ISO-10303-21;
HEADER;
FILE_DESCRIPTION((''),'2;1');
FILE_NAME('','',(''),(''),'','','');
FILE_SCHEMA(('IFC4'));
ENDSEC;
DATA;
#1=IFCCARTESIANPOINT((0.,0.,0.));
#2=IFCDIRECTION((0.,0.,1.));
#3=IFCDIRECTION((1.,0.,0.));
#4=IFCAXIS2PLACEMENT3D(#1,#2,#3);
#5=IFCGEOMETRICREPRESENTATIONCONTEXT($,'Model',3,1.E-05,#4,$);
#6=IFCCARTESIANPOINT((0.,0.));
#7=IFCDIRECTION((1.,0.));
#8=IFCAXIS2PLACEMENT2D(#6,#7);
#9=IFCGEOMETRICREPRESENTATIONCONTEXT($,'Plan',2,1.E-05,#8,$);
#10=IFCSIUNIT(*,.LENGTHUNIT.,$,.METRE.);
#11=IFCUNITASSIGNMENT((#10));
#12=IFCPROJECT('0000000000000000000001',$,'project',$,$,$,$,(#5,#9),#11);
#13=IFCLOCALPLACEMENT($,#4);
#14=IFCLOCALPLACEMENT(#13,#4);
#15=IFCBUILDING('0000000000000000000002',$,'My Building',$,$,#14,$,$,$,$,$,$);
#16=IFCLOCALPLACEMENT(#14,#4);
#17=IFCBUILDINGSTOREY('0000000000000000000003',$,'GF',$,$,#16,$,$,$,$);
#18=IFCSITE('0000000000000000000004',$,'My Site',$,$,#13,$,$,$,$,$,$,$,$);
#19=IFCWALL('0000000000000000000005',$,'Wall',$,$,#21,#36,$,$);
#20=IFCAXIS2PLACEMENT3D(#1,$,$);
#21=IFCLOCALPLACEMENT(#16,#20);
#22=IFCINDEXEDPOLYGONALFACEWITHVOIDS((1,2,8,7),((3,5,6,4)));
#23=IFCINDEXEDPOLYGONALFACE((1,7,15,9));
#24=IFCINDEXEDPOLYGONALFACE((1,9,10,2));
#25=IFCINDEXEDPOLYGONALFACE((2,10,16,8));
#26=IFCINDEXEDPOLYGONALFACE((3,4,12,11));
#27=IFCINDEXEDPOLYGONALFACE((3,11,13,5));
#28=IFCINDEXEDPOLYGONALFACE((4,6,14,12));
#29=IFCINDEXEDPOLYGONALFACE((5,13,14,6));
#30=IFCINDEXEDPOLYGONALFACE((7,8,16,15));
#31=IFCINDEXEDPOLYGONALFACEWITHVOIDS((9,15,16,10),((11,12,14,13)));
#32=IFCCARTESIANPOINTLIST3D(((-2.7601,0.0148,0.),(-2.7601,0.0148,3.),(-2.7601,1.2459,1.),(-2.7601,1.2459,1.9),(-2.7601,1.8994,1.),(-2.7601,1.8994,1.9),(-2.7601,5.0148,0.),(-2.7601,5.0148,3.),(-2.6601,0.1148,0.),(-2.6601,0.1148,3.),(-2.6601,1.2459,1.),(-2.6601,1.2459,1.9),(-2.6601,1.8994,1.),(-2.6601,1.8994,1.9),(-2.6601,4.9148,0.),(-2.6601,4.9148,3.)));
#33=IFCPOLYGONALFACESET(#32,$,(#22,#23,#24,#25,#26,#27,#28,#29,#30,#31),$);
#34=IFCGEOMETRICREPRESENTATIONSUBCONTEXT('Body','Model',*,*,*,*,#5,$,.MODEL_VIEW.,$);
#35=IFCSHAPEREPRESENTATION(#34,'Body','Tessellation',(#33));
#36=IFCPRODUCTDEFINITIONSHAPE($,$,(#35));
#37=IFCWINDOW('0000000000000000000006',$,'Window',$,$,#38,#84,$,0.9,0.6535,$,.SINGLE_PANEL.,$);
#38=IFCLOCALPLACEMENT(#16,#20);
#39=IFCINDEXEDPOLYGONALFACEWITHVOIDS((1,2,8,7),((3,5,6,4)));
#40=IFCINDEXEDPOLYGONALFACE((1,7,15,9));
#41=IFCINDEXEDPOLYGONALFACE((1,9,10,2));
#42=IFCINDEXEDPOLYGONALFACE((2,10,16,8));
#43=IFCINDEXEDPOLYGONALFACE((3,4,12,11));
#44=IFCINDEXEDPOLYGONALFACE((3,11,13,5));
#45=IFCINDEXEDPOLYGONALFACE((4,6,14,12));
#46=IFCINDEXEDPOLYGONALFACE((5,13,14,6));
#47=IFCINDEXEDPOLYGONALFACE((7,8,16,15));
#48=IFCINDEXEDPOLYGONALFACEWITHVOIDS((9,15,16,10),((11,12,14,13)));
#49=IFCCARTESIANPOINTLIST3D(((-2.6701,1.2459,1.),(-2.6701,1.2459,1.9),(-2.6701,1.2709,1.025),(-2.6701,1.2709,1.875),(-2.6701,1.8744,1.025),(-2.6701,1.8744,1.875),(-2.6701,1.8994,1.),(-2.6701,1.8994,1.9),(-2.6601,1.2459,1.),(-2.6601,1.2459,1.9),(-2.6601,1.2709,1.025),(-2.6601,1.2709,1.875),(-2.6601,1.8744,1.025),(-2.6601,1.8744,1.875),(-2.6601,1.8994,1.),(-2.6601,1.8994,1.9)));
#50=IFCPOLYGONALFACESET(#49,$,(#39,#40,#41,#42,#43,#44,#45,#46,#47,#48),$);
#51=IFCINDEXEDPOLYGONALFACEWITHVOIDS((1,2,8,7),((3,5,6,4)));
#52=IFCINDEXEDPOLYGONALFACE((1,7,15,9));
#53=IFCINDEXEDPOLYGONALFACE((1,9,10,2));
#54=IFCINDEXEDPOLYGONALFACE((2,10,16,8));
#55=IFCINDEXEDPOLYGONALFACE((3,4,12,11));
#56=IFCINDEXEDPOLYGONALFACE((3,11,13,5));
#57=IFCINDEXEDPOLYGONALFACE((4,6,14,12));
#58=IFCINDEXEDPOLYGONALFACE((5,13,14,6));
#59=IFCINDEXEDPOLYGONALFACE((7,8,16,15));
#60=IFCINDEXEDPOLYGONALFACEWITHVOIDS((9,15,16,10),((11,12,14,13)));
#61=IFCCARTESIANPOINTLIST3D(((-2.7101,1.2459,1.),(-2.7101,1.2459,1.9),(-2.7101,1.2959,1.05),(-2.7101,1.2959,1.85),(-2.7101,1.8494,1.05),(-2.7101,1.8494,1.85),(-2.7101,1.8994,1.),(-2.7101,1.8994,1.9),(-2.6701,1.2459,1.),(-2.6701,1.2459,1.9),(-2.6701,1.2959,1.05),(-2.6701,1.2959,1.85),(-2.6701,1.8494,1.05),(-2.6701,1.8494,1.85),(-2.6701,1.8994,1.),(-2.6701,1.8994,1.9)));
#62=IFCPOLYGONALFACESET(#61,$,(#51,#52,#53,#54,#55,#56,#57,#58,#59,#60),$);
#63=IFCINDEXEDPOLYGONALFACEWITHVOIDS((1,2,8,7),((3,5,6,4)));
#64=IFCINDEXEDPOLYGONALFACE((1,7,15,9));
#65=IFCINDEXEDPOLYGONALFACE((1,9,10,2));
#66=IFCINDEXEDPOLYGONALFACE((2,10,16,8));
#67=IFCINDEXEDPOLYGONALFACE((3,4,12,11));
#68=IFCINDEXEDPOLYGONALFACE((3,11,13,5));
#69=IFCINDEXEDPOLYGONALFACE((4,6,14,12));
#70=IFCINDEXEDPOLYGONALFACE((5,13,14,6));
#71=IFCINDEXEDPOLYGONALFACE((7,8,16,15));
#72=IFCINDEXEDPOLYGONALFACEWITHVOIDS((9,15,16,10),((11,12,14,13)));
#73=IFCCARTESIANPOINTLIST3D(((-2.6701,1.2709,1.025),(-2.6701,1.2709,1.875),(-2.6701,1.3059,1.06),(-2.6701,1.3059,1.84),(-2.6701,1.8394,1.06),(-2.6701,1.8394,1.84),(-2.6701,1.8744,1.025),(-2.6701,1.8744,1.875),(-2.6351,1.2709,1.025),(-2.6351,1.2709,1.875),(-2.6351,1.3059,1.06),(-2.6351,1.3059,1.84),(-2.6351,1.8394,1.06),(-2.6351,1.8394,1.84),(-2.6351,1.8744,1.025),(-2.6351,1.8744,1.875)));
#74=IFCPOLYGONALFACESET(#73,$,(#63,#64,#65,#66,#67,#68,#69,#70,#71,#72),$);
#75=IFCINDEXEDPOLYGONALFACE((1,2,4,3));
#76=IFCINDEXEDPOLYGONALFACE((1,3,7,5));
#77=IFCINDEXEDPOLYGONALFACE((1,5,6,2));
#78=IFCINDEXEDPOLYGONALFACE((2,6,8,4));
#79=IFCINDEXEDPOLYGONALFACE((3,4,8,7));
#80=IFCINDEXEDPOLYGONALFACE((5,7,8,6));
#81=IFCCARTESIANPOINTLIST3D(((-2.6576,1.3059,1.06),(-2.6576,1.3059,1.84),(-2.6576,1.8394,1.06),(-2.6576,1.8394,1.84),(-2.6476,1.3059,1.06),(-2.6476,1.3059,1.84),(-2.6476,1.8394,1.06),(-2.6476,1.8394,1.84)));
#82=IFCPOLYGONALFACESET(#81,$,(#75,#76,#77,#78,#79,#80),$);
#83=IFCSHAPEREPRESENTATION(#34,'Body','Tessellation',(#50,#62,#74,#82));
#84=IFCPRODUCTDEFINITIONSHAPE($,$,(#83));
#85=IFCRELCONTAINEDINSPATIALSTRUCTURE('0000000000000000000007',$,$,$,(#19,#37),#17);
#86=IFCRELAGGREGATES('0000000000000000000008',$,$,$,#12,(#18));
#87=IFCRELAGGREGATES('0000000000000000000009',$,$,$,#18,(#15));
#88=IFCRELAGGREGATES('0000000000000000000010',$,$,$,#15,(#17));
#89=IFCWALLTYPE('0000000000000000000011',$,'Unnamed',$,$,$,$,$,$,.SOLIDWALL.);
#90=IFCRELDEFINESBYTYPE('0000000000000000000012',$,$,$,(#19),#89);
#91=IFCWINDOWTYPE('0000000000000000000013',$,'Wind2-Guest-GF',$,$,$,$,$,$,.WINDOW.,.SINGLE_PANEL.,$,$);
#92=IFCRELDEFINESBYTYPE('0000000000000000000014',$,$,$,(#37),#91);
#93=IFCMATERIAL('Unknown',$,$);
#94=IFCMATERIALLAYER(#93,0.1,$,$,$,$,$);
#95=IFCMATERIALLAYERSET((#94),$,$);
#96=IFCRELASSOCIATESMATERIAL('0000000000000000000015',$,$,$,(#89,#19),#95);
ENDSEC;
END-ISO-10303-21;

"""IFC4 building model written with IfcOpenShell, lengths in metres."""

from ifc_helpers import new_model, entity, si_unit, frame, origin_with_axes, origin_2d_with_axis, place, context, subcontext, project, spatial, line, indexed_curve, outline, extrude, shape, source, transform, mapped, material, layer, layer_set, layer_usage, type_object, type_shapes, element, fill, save


model = new_model("IFC4")

# Units and contexts
model_context = context("Model", 3, precision=1e-05, world=origin_with_axes())
plan_context = context("Plan", 2, precision=1e-05, world=origin_2d_with_axis())
body_context_1 = subcontext(model_context, "Body", "Model", "MODEL_VIEW")
body_context_2 = subcontext(plan_context, "Body", "Plan", "PLAN_VIEW")
ifc_project = project(units=[si_unit("LENGTHUNIT", "METRE")], contexts=[model_context, plan_context])

# Site, building, storey
site_placement = place(None, origin_with_axes())
site = spatial("IfcSite", under=ifc_project, at=site_placement, Name="My Site")
building_placement = place(site_placement, origin_with_axes())
building = spatial("IfcBuilding", under=site, at=building_placement, Name="My Building")
storey_placement = place(building_placement, origin_with_axes())
storey = spatial("IfcBuildingStorey", under=building, at=storey_placement, Name="GF")

# Shared definitions
ifc_material = material(Name="Unknown")

# Shared definitions
ifc_layer_1 = layer(ifc_material, 0.1)
ifc_layer_set_1 = layer_set([ifc_layer_1])
wall_type = type_object("IfcWallType", Name="Unnamed", PredefinedType="SOLIDWALL", material=ifc_layer_set_1)

# Wall, opening, window
ifc_layer_usage_1 = layer_usage(ifc_layer_set_1, "AXIS2", "POSITIVE", 0.0)
wall_1_placement = place(storey_placement, frame((-2.7601, 5.0148, 0.0), z_axis=(0.0, 0.0, 1.0), x_axis=(0.0, -1.0, 0.0)))
wall_1 = element("IfcWall", 1, at=wall_1_placement, inside=storey, type_object=wall_type, material=ifc_layer_usage_1, Name="Wall", context=body_context_1, shape_type="SweptSolid", body=[
    extrude(outline(indexed_curve([(0.0, 0.0), (0.1, 0.1), (4.9, 0.1), (5.0, 0.0)], segments=[line(1, 2, 3, 4, 1)])), origin_with_axes(), (0.0, 0.0, 1.0), 3.0),
])
shared_shape_1 = source(origin_with_axes(), body_context_1, "Body", "SweptSolid", [
    extrude(outline(indexed_curve([(0.0, 0.0), (0.6535, 0.0), (0.6535, 0.9), (0.0, 0.9)], segments=[line(1, 2, 3, 4, 1)])), frame((0.0, -0.6, 0.0), z_axis=(0.0, -1.0, 0.0), x_axis=(1.0, 0.0, 0.0)), (0.0, 0.0, -1.0), 1.2),
])
opening_1_placement = place(wall_1_placement, frame((3.1154, 0.0, 1.0), z_axis=(0.0, 0.0, 1.0), x_axis=(1.0, 0.0, 0.0)))
opening_1 = element("IfcOpeningElement", 2, at=opening_1_placement, cuts=wall_1, PredefinedType="OPENING", context=body_context_1, shape_type="MappedRepresentation", body=[
    mapped(shared_shape_1, transform((0.0, 0.0, 0.0), x_axis=(1.0, 0.0, 0.0), y_axis=(0.0, 1.0, 0.0), z_axis=(0.0, 0.0, 1.0), scale=1.0)),
])
window_type_1 = type_object("IfcWindowType", Name="Wind2-Guest-GF", PartitioningType="SINGLE_PANEL", PredefinedType="WINDOW")
shared_shape_2 = source(origin_with_axes(), body_context_1, "Body", "SweptSolid", [
    extrude(outline(indexed_curve([(0.0, 0.0), (0.6535, 0.0), (0.6535, 0.9), (0.0, 0.9)], segments=[line(1, 2, 3, 4, 1)]), holes=[indexed_curve([(0.025, 0.025), (0.6285, 0.025), (0.6285, 0.875), (0.025, 0.875)], segments=[line(1, 2, 3, 4, 1)])]), frame((0.0, 0.09, 0.0), z_axis=(0.0, -1.0, 0.0), x_axis=(1.0, 0.0, 0.0)), (0.0, 0.0, -1.0), 0.01),
    extrude(outline(indexed_curve([(0.0, 0.0), (0.6535, 0.0), (0.6535, 0.9), (0.0, 0.9)], segments=[line(1, 2, 3, 4, 1)]), holes=[indexed_curve([(0.05, 0.05), (0.6035, 0.05), (0.6035, 0.85), (0.05, 0.85)], segments=[line(1, 2, 3, 4, 1)])]), frame((0.0, 0.05, 0.0), z_axis=(0.0, -1.0, 0.0), x_axis=(1.0, 0.0, 0.0)), (0.0, 0.0, -1.0), 0.04),
    extrude(outline(indexed_curve([(0.0, 0.0), (0.6035, 0.0), (0.6035, 0.85), (0.0, 0.85)], segments=[line(1, 2, 3, 4, 1)]), holes=[indexed_curve([(0.035, 0.035), (0.5685, 0.035), (0.5685, 0.815), (0.035, 0.815)], segments=[line(1, 2, 3, 4, 1)])]), frame((0.025, 0.09, 0.025), z_axis=(0.0, -1.0, 0.0), x_axis=(1.0, 0.0, 0.0)), (0.0, 0.0, -1.0), 0.035),
    extrude(outline(indexed_curve([(0.035, 0.035), (0.5685, 0.035), (0.5685, 0.815), (0.035, 0.815)], segments=[line(1, 2, 3, 4, 1)])), frame((0.025, 0.1025, 0.025), z_axis=(0.0, -1.0, 0.0), x_axis=(1.0, 0.0, 0.0)), (0.0, 0.0, -1.0), 0.01),
])
shared_shape_3 = source(origin_with_axes(), body_context_2, "Body", "Curve2D", [
    entity("IfcIndexedPolyCurve", entity("IfcCartesianPointList2D", [[0.05, 0.05], [0.6035, 0.05]])),
    entity("IfcIndexedPolyCurve", entity("IfcCartesianPointList2D", [[0.0, 0.1], [0.025, 0.1], [0.025, 0.09], [0.05, 0.09], [0.05, 0.05], [0.0, 0.05]]), [entity("IfcLineIndex", [1, 2, 3, 4, 5, 6, 1])]),
    entity("IfcIndexedPolyCurve", entity("IfcCartesianPointList2D", [[0.6535, 0.1], [0.6285, 0.1], [0.6285, 0.09], [0.6035, 0.09], [0.6035, 0.05], [0.6535, 0.05]]), [entity("IfcLineIndex", [1, 2, 3, 4, 5, 6, 1])]),
    entity("IfcIndexedPolyCurve", entity("IfcCartesianPointList2D", [[0.025, 0.09], [0.06, 0.09], [0.06, 0.125], [0.025, 0.125]]), [entity("IfcLineIndex", [1, 2, 3, 4, 1])]),
    entity("IfcIndexedPolyCurve", entity("IfcCartesianPointList2D", [[0.6285, 0.09], [0.5935, 0.09], [0.5935, 0.125], [0.6285, 0.125]]), [entity("IfcLineIndex", [1, 2, 3, 4, 1])]),
    entity("IfcIndexedPolyCurve", entity("IfcCartesianPointList2D", [[0.06, 0.09], [0.5935, 0.09]])),
    entity("IfcIndexedPolyCurve", entity("IfcCartesianPointList2D", [[0.06, 0.125], [0.5935, 0.125]])),
    entity("IfcIndexedPolyCurve", entity("IfcCartesianPointList2D", [[0.06, 0.1075], [0.5935, 0.1075]])),
])
type_shapes(window_type_1, [shared_shape_2, shared_shape_3])
window_1_placement = place(opening_1_placement, frame((0.0, 0.0, 0.0), z_axis=(0.0, 0.0, 1.0), x_axis=(1.0, 0.0, 0.0)))
window_1 = element("IfcWindow", 3, at=window_1_placement, inside=storey, type_object=window_type_1, Name="Window", OverallHeight=0.9, OverallWidth=0.6535, PartitioningType="SINGLE_PANEL", shapes=[
    shape(body_context_1, "Body", "MappedRepresentation", [mapped(shared_shape_2, transform((0.0, 0.0, 0.0), x_axis=(1.0, 0.0, 0.0), y_axis=(0.0, 1.0, 0.0), z_axis=(0.0, 0.0, 1.0), scale=1.0))]),
    shape(body_context_2, "Body", "MappedRepresentation", [mapped(shared_shape_3, transform((0.0, 0.0, 0.0), x_axis=(1.0, 0.0, 0.0), y_axis=(0.0, 1.0, 0.0), z_axis=(0.0, 0.0, 1.0), scale=1.0))]),
])
fill(opening_1, window_1)

save(model, "model.ifc")
